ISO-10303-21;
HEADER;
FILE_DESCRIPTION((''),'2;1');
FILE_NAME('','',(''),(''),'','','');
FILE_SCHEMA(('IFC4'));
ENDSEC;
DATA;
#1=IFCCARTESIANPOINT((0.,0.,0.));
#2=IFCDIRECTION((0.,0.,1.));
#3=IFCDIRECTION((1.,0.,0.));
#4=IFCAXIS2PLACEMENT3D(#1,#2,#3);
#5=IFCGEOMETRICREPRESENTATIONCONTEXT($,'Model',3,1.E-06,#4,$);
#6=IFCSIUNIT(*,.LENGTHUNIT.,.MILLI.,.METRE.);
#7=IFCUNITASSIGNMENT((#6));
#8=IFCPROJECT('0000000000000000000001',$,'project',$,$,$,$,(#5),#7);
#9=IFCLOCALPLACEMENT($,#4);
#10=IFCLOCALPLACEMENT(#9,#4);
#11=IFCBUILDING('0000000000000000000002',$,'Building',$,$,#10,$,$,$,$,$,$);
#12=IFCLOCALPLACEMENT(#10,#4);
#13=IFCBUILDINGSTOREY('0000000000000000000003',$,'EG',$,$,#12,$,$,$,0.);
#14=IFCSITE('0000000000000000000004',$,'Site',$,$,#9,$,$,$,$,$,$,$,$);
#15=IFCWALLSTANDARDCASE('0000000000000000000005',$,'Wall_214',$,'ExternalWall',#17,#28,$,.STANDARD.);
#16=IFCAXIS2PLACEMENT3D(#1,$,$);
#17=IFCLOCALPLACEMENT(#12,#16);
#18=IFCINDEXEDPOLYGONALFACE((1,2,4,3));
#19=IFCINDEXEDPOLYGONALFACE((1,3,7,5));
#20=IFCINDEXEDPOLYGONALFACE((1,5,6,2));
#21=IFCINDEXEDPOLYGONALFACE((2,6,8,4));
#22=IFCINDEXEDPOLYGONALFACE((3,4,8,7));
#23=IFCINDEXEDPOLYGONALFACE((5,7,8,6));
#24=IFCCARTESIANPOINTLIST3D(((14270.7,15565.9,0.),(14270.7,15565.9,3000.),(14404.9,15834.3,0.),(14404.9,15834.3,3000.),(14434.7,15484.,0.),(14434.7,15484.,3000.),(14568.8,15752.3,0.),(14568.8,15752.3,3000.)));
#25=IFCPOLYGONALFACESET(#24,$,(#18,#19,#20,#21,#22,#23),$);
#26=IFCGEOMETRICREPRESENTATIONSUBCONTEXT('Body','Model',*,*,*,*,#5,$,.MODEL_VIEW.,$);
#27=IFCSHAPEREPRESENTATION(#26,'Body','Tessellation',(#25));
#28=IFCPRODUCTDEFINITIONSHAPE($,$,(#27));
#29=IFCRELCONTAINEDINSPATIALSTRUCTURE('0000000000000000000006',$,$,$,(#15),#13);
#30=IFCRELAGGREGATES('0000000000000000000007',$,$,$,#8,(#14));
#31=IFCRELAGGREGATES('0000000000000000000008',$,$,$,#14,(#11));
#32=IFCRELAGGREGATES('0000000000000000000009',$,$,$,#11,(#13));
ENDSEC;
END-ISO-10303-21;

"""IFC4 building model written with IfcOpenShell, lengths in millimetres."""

from ifc_helpers import new_model, si_unit, frame, origin_with_axes, place, context, subcontext, project, spatial, rectangle, extrude, element, save


model = new_model("IFC4")

# Units and contexts
model_context = context("Model", 3, precision=1e-06, world=origin_with_axes())
body_context = subcontext(model_context, "Body", "Model", "MODEL_VIEW")
ifc_project = project(units=[si_unit("LENGTHUNIT", "METRE", prefix="MILLI")], contexts=[model_context])

# Site, building, storey
site_placement = place(None, origin_with_axes())
site = spatial("IfcSite", under=ifc_project, at=site_placement, Name="Site")
building_placement = place(site_placement, origin_with_axes())
building = spatial("IfcBuilding", under=site, at=building_placement, Name="Building")
storey_placement = place(building_placement, origin_with_axes())
storey = spatial("IfcBuildingStorey", under=building, at=storey_placement, Name="EG", Elevation=0.0)

# Wall
wall_1_placement = place(storey_placement, origin_with_axes())
element("IfcWallStandardCase", 1, at=wall_1_placement, inside=storey, Name="Wall_214", ObjectType="ExternalWall", PredefinedType="STANDARD", context=body_context, shape_type="SweptSolid", body=[
    extrude(rectangle(XDim=183.3, YDim=300.0), frame((14419.8, 15659.1, 0.0), z_axis=(0.0, 0.0, 1.0), x_axis=(-0.894427, 0.447214, 0.0)), (0.0, 0.0, 1.0), 3000.0),
])

save(model, "model.ifc")
